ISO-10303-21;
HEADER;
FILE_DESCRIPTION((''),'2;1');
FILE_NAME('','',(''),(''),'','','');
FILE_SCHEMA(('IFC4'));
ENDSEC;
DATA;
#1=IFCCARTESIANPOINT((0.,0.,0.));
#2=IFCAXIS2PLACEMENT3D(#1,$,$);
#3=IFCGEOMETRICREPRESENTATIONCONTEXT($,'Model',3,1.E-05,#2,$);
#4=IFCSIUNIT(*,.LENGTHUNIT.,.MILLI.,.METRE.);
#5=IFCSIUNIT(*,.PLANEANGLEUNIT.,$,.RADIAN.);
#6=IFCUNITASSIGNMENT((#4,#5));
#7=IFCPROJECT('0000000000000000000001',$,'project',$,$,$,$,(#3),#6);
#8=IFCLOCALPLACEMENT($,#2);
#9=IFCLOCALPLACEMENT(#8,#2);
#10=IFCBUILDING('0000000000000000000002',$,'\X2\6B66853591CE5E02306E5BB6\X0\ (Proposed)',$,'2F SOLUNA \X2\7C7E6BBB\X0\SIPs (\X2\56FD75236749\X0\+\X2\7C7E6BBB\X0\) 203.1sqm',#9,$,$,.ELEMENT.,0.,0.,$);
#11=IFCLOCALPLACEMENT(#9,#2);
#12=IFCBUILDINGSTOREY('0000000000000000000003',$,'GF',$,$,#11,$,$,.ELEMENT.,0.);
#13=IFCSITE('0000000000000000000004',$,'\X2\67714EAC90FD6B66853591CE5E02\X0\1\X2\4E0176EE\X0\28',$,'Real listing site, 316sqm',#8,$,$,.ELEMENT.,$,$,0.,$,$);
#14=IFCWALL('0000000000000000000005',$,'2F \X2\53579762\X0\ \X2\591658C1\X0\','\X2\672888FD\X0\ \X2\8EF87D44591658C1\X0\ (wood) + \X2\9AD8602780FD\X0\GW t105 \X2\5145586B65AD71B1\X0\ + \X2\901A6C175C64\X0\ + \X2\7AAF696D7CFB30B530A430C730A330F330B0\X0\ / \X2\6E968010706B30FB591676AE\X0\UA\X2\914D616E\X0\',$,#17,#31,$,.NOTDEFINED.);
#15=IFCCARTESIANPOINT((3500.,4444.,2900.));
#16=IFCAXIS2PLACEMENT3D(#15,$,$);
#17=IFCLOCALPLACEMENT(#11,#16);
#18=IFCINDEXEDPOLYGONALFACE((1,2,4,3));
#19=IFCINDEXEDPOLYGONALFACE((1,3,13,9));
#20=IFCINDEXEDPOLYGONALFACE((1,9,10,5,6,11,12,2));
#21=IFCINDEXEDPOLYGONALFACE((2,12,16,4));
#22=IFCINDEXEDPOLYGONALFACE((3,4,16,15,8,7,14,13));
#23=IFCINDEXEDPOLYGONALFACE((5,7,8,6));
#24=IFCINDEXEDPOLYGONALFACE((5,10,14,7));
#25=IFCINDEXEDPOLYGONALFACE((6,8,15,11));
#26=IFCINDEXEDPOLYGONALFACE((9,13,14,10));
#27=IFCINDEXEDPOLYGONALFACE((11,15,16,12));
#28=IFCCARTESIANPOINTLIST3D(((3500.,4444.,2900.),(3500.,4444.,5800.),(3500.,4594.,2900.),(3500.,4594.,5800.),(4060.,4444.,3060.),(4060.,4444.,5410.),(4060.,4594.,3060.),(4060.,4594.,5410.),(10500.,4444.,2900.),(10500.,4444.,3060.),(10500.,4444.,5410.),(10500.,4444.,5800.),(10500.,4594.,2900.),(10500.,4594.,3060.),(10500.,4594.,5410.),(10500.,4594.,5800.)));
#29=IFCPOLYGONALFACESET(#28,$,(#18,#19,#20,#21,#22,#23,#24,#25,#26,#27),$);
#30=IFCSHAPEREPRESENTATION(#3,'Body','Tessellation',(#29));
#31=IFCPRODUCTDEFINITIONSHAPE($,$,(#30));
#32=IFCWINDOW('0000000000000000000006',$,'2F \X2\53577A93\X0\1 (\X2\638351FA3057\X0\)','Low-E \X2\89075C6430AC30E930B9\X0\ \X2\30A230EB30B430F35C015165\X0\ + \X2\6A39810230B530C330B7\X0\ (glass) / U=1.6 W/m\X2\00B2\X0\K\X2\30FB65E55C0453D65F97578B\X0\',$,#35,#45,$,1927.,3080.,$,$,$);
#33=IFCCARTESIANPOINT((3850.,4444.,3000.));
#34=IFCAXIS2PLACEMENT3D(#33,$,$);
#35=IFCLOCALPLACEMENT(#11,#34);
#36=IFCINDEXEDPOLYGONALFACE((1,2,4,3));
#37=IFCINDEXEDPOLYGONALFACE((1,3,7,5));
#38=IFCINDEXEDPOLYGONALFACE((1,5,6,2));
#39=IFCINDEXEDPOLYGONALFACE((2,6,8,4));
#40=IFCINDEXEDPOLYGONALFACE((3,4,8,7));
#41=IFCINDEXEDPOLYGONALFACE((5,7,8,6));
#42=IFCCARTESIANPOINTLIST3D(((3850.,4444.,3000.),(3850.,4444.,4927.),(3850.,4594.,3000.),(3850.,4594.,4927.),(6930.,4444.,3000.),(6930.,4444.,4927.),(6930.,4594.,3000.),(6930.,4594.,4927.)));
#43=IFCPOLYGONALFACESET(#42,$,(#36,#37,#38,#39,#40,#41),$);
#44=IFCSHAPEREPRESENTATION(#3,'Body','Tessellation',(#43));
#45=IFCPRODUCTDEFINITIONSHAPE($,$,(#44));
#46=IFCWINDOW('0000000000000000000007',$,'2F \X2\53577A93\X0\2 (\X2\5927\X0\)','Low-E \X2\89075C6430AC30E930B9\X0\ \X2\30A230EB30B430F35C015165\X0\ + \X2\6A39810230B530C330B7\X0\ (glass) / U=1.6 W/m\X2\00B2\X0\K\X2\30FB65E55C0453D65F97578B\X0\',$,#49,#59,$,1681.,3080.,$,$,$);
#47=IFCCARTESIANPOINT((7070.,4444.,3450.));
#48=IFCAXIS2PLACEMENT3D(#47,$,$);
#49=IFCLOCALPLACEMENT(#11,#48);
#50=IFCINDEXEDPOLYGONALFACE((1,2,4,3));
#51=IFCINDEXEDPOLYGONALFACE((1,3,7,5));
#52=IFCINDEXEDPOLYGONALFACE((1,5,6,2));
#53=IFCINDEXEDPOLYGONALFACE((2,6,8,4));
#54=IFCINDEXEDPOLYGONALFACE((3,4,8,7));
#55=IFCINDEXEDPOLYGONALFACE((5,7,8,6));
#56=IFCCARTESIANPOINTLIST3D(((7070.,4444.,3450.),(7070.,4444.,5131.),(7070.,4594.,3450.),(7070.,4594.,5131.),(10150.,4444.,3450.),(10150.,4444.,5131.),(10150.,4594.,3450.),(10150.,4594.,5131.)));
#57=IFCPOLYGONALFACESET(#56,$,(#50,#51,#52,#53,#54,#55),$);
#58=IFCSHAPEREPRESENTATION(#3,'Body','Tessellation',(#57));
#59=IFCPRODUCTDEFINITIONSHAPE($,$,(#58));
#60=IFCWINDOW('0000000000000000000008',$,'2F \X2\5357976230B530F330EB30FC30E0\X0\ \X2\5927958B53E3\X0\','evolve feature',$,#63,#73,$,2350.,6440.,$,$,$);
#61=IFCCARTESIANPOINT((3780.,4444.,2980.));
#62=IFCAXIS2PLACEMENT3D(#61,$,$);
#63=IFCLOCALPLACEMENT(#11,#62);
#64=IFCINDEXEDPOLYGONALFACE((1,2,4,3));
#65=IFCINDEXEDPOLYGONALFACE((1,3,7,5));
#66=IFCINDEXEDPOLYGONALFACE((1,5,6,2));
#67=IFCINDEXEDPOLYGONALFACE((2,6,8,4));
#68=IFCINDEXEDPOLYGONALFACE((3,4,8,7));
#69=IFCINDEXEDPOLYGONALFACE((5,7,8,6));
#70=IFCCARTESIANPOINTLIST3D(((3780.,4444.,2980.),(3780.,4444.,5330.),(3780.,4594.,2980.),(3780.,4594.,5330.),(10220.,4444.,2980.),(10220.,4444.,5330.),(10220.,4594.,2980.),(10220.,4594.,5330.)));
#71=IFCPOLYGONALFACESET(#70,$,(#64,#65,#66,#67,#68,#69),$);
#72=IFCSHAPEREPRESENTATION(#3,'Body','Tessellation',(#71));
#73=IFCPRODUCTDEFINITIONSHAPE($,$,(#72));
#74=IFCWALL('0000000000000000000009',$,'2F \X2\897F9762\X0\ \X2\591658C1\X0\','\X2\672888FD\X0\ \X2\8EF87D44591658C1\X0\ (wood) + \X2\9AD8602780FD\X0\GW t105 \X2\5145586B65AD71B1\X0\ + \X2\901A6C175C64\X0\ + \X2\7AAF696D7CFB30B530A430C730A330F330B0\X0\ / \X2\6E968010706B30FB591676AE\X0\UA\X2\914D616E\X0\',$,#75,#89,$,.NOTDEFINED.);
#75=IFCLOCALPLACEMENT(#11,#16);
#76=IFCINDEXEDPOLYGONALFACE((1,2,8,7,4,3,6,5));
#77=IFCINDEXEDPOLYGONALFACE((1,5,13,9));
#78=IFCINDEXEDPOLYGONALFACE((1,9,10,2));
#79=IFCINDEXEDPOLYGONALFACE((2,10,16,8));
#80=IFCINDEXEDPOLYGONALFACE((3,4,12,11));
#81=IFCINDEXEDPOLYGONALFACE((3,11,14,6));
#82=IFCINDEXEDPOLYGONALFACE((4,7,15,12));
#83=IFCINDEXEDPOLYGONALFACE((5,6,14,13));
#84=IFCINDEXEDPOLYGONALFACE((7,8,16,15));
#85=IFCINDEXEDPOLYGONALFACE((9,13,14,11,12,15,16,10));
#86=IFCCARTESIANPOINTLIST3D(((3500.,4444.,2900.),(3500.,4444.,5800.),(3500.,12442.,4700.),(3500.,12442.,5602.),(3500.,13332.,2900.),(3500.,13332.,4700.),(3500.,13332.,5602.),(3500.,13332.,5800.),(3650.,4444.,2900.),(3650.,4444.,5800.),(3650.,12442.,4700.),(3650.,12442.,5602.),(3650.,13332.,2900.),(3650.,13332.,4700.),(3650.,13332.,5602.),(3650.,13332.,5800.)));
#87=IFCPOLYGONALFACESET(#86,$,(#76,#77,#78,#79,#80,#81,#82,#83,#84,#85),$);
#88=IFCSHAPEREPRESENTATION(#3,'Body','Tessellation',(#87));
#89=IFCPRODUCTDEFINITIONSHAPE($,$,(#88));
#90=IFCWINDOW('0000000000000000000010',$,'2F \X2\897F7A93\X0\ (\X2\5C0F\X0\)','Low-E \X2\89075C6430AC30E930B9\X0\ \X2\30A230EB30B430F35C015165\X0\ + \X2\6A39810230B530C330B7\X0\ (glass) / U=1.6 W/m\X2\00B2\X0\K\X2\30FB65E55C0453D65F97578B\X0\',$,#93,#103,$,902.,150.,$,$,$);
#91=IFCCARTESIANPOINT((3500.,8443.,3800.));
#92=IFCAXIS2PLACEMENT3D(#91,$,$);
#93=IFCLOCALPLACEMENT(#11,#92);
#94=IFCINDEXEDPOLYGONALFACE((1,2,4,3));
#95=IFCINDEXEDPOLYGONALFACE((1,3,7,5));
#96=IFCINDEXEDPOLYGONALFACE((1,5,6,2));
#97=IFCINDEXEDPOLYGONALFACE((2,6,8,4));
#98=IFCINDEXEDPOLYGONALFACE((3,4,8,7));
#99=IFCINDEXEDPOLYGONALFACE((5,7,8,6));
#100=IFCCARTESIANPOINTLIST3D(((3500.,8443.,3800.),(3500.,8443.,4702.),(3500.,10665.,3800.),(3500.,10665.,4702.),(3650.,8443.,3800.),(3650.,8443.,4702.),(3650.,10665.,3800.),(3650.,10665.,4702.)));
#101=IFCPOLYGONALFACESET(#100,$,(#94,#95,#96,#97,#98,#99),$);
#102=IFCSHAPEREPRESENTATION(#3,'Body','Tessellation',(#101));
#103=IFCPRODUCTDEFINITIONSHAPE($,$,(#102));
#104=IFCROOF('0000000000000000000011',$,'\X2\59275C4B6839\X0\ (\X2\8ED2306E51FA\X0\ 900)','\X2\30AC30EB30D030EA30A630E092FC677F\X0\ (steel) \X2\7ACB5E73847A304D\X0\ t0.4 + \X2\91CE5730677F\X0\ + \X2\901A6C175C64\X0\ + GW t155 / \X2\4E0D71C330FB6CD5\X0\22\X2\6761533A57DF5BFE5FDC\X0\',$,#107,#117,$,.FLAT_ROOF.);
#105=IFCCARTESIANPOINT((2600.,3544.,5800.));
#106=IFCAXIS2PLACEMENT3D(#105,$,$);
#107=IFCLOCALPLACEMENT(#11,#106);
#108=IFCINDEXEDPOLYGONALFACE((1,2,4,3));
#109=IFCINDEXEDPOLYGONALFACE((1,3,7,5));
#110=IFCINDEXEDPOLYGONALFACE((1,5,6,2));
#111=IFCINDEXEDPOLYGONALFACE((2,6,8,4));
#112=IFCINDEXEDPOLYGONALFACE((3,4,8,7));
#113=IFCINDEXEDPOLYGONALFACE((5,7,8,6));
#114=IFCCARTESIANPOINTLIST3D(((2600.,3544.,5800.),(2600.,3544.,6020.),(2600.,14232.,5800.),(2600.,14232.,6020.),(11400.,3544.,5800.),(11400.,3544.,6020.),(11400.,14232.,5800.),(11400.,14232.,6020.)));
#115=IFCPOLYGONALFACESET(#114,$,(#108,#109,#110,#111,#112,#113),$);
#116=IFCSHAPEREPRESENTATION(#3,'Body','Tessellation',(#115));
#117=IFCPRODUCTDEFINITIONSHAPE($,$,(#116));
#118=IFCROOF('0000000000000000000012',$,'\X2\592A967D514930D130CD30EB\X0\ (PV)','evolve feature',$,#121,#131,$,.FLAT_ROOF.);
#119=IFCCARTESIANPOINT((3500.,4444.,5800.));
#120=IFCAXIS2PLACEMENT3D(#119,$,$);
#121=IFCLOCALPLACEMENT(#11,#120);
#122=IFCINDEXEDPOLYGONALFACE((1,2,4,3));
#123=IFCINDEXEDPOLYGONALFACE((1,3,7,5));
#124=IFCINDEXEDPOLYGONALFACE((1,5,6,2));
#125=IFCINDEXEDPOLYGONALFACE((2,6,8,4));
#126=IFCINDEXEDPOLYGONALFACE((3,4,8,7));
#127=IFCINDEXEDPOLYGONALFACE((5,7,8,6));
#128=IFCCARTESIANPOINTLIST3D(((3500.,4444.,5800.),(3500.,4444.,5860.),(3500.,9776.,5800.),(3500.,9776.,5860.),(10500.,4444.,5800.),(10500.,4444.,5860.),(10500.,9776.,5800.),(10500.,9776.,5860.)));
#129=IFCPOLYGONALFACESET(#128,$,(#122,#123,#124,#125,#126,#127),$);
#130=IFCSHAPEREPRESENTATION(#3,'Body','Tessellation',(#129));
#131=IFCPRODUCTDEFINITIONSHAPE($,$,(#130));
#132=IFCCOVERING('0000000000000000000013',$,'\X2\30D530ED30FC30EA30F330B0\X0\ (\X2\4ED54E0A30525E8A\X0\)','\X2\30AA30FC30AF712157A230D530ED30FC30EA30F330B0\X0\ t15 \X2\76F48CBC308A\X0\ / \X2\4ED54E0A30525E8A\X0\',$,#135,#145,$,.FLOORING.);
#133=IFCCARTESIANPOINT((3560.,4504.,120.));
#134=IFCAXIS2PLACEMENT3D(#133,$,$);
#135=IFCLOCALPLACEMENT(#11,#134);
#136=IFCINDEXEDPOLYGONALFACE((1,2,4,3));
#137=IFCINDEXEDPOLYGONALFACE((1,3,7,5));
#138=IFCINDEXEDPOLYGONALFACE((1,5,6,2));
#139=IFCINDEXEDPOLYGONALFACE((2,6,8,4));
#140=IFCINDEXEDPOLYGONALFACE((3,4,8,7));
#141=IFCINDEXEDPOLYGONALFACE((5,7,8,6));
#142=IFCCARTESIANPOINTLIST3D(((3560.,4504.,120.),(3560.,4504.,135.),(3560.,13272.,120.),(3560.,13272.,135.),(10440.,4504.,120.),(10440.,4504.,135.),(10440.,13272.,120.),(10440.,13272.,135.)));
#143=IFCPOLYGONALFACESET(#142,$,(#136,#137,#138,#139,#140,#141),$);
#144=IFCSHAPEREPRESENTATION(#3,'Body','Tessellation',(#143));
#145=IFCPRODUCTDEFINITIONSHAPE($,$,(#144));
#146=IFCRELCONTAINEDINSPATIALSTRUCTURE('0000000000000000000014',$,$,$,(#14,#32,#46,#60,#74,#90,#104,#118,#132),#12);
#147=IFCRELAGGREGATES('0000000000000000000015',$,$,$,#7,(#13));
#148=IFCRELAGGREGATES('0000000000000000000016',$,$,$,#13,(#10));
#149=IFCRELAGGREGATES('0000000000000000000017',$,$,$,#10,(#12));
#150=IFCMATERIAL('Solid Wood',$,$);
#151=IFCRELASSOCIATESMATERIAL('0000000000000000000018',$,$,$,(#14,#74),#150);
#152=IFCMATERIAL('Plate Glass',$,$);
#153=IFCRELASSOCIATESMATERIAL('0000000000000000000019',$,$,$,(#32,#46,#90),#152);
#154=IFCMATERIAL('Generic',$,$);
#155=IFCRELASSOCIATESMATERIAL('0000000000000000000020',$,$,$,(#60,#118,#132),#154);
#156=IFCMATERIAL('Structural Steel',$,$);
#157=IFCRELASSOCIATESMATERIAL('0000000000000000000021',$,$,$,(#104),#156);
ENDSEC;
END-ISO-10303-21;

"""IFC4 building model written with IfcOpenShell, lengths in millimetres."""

from ifc_helpers import new_model, si_unit, frame, frame_2d, origin, place, context, project, spatial, rectangle, extrude, material, element, fill, save


model = new_model("IFC4")

# Units and contexts
model_context = context("Model", 3, precision=1e-05, world=origin())
ifc_project = project(units=[si_unit("LENGTHUNIT", "METRE", prefix="MILLI"), si_unit("PLANEANGLEUNIT", "RADIAN")], contexts=[model_context])

# Site, building, storey
site_placement = place(None, origin())
site = spatial("IfcSite", under=ifc_project, at=site_placement, Name="東京都武蔵野市1丁目28", ObjectType="Real listing site, 316sqm", CompositionType="ELEMENT", RefElevation=0.0)
building_placement = place(site_placement, origin())
building = spatial("IfcBuilding", under=site, at=building_placement, Name="武蔵野市の家 (Proposed)", ObjectType="2F SOLUNA 籾殻SIPs (国産杉+籾殻) 203.1sqm", CompositionType="ELEMENT", ElevationOfRefHeight=0.0, ElevationOfTerrain=0.0)
storey_placement = place(building_placement, origin())
storey = spatial("IfcBuildingStorey", under=building, at=storey_placement, Name="GF", CompositionType="ELEMENT", Elevation=0.0)

# Shared definitions
ifc_material_1 = material(Name="Solid Wood")

# Shared definitions
ifc_material_2 = material(Name="Plate Glass")
ifc_material_3 = material(Name="Generic")

# Wall, openings, windows
wall_1_placement = place(storey_placement, frame((3500.0, 4444.0, 2900.0)))
wall_1 = element("IfcWall", 1, at=wall_1_placement, inside=storey, material=ifc_material_1, Name="2F 南面 外壁", Description="木製 軸組外壁 (wood) + 高性能GW t105 充填断熱 + 通気層 + 窯業系サイディング / 準耐火・外皮UA配慮", PredefinedType="NOTDEFINED", context=model_context, shape_type="SweptSolid", body=[
    extrude(rectangle(XDim=7000.0, YDim=150.0, at=frame_2d((3500.0, 75.0))), frame((3500.0, 4444.0, 2900.0)), (0.0, 0.0, 1.0), 2900.0),
])
opening_1_placement = place(storey_placement, frame((3850.0, 4444.0, 3000.0)))
opening_1 = element("IfcOpeningElement", 2, at=opening_1_placement, cuts=wall_1, PredefinedType="NOTDEFINED", context=model_context, shape_type="SweptSolid", body=[
    extrude(rectangle(XDim=3080.0, YDim=150.0, at=frame_2d((1540.0, 75.0))), frame((3850.0, 4444.0, 3000.0)), (0.0, 0.0, 1.0), 1927.0),
])
opening_2_placement = place(storey_placement, frame((7070.0, 4444.0, 3450.0)))
opening_2 = element("IfcOpeningElement", 3, at=opening_2_placement, cuts=wall_1, PredefinedType="NOTDEFINED", context=model_context, shape_type="SweptSolid", body=[
    extrude(rectangle(XDim=3080.0, YDim=150.0, at=frame_2d((1540.0, 75.0))), frame((7070.0, 4444.0, 3450.0)), (0.0, 0.0, 1.0), 1681.0),
])
opening_3_placement = place(storey_placement, frame((3780.0, 4444.0, 2980.0)))
opening_3 = element("IfcOpeningElement", 4, at=opening_3_placement, cuts=wall_1, PredefinedType="NOTDEFINED", context=model_context, shape_type="SweptSolid", body=[
    extrude(rectangle(XDim=6440.0, YDim=150.0, at=frame_2d((3220.0, 75.0))), frame((3780.0, 4444.0, 2980.0)), (0.0, 0.0, 1.0), 2350.0),
])
window_1_placement = place(storey_placement, frame((3850.0, 4444.0, 3000.0)))
window_1 = element("IfcWindow", 5, at=window_1_placement, inside=storey, material=ifc_material_2, Name="2F 南窓1 (掃出し)", Description="Low-E 複層ガラス アルゴン封入 + 樹脂サッシ (glass) / U=1.6 W/m²K・日射取得型", OverallHeight=1927.0, OverallWidth=3080.0, context=model_context, shape_type="SweptSolid", body=[
    extrude(rectangle(XDim=3080.0, YDim=150.0, at=frame_2d((1540.0, 75.0))), frame((3850.0, 4444.0, 3000.0)), (0.0, 0.0, 1.0), 1927.0),
])
fill(opening_1, window_1)
window_2_placement = place(storey_placement, frame((7070.0, 4444.0, 3450.0)))
window_2 = element("IfcWindow", 6, at=window_2_placement, inside=storey, material=ifc_material_2, Name="2F 南窓2 (大)", Description="Low-E 複層ガラス アルゴン封入 + 樹脂サッシ (glass) / U=1.6 W/m²K・日射取得型", OverallHeight=1681.0, OverallWidth=3080.0, context=model_context, shape_type="SweptSolid", body=[
    extrude(rectangle(XDim=3080.0, YDim=150.0, at=frame_2d((1540.0, 75.0))), frame((7070.0, 4444.0, 3450.0)), (0.0, 0.0, 1.0), 1681.0),
])
fill(opening_2, window_2)
window_3_placement = place(storey_placement, frame((3780.0, 4444.0, 2980.0)))
window_3 = element("IfcWindow", 7, at=window_3_placement, inside=storey, material=ifc_material_3, Name="2F 南面サンルーム 大開口", Description="evolve feature", OverallHeight=2350.0, OverallWidth=6440.0, context=model_context, shape_type="SweptSolid", body=[
    extrude(rectangle(XDim=6440.0, YDim=150.0, at=frame_2d((3220.0, 75.0))), frame((3780.0, 4444.0, 2980.0)), (0.0, 0.0, 1.0), 2350.0),
])
fill(opening_3, window_3)

# Wall, opening, window
wall_2_placement = place(storey_placement, frame((3500.0, 4444.0, 2900.0)))
wall_2 = element("IfcWall", 8, at=wall_2_placement, inside=storey, material=ifc_material_1, Name="2F 西面 外壁", Description="木製 軸組外壁 (wood) + 高性能GW t105 充填断熱 + 通気層 + 窯業系サイディング / 準耐火・外皮UA配慮", PredefinedType="NOTDEFINED", context=model_context, shape_type="SweptSolid", body=[
    extrude(rectangle(XDim=150.0, YDim=8888.0, at=frame_2d((75.0, 4444.0))), frame((3500.0, 4444.0, 2900.0)), (0.0, 0.0, 1.0), 2900.0),
])
opening_4_placement = place(storey_placement, frame((3500.0, 8443.0, 3800.0)))
opening_4 = element("IfcOpeningElement", 9, at=opening_4_placement, cuts=wall_2, PredefinedType="NOTDEFINED", context=model_context, shape_type="SweptSolid", body=[
    extrude(rectangle(XDim=150.0, YDim=2222.0, at=frame_2d((75.0, 1111.0))), frame((3500.0, 8443.0, 3800.0)), (0.0, 0.0, 1.0), 902.0),
])
window_4_placement = place(storey_placement, frame((3500.0, 8443.0, 3800.0)))
window_4 = element("IfcWindow", 10, at=window_4_placement, inside=storey, material=ifc_material_2, Name="2F 西窓 (小)", Description="Low-E 複層ガラス アルゴン封入 + 樹脂サッシ (glass) / U=1.6 W/m²K・日射取得型", OverallHeight=902.0, OverallWidth=150.0, context=model_context, shape_type="SweptSolid", body=[
    extrude(rectangle(XDim=150.0, YDim=2222.0, at=frame_2d((75.0, 1111.0))), frame((3500.0, 8443.0, 3800.0)), (0.0, 0.0, 1.0), 902.0),
])
fill(opening_4, window_4)

# Roofs
ifc_material_4 = material(Name="Structural Steel")
roof_1_placement = place(storey_placement, frame((2600.0, 3544.0, 5800.0)))
element("IfcRoof", 11, at=roof_1_placement, inside=storey, material=ifc_material_4, Name="大屋根 (軒の出 900)", Description="ガルバリウム鋼板 (steel) 立平葺き t0.4 + 野地板 + 通気層 + GW t155 / 不燃・法22条区域対応", PredefinedType="FLAT_ROOF", context=model_context, shape_type="SweptSolid", body=[
    extrude(rectangle(XDim=8800.0, YDim=10688.0, at=frame_2d((4400.0, 5344.0))), frame((2600.0, 3544.0, 5800.0)), (0.0, 0.0, 1.0), 220.0),
])
roof_2_placement = place(storey_placement, frame((3500.0, 4444.0, 5800.0)))
element("IfcRoof", 12, at=roof_2_placement, inside=storey, material=ifc_material_3, Name="太陽光パネル (PV)", Description="evolve feature", PredefinedType="FLAT_ROOF", context=model_context, shape_type="SweptSolid", body=[
    extrude(rectangle(XDim=7000.0, YDim=5332.0, at=frame_2d((3500.0, 2666.0))), frame((3500.0, 4444.0, 5800.0)), (0.0, 0.0, 1.0), 60.0),
])

# Covering
covering_placement = place(storey_placement, frame((3560.0, 4504.0, 120.0)))
element("IfcCovering", 13, at=covering_placement, inside=storey, material=ifc_material_3, Name="フローリング (仕上げ床)", Description="オーク無垢フローリング t15 直貼り / 仕上げ床", PredefinedType="FLOORING", context=model_context, shape_type="SweptSolid", body=[
    extrude(rectangle(XDim=6880.0, YDim=8768.0, at=frame_2d((3440.0, 4384.0))), frame((3560.0, 4504.0, 120.0)), (0.0, 0.0, 1.0), 15.0),
])

save(model, "model.ifc")
